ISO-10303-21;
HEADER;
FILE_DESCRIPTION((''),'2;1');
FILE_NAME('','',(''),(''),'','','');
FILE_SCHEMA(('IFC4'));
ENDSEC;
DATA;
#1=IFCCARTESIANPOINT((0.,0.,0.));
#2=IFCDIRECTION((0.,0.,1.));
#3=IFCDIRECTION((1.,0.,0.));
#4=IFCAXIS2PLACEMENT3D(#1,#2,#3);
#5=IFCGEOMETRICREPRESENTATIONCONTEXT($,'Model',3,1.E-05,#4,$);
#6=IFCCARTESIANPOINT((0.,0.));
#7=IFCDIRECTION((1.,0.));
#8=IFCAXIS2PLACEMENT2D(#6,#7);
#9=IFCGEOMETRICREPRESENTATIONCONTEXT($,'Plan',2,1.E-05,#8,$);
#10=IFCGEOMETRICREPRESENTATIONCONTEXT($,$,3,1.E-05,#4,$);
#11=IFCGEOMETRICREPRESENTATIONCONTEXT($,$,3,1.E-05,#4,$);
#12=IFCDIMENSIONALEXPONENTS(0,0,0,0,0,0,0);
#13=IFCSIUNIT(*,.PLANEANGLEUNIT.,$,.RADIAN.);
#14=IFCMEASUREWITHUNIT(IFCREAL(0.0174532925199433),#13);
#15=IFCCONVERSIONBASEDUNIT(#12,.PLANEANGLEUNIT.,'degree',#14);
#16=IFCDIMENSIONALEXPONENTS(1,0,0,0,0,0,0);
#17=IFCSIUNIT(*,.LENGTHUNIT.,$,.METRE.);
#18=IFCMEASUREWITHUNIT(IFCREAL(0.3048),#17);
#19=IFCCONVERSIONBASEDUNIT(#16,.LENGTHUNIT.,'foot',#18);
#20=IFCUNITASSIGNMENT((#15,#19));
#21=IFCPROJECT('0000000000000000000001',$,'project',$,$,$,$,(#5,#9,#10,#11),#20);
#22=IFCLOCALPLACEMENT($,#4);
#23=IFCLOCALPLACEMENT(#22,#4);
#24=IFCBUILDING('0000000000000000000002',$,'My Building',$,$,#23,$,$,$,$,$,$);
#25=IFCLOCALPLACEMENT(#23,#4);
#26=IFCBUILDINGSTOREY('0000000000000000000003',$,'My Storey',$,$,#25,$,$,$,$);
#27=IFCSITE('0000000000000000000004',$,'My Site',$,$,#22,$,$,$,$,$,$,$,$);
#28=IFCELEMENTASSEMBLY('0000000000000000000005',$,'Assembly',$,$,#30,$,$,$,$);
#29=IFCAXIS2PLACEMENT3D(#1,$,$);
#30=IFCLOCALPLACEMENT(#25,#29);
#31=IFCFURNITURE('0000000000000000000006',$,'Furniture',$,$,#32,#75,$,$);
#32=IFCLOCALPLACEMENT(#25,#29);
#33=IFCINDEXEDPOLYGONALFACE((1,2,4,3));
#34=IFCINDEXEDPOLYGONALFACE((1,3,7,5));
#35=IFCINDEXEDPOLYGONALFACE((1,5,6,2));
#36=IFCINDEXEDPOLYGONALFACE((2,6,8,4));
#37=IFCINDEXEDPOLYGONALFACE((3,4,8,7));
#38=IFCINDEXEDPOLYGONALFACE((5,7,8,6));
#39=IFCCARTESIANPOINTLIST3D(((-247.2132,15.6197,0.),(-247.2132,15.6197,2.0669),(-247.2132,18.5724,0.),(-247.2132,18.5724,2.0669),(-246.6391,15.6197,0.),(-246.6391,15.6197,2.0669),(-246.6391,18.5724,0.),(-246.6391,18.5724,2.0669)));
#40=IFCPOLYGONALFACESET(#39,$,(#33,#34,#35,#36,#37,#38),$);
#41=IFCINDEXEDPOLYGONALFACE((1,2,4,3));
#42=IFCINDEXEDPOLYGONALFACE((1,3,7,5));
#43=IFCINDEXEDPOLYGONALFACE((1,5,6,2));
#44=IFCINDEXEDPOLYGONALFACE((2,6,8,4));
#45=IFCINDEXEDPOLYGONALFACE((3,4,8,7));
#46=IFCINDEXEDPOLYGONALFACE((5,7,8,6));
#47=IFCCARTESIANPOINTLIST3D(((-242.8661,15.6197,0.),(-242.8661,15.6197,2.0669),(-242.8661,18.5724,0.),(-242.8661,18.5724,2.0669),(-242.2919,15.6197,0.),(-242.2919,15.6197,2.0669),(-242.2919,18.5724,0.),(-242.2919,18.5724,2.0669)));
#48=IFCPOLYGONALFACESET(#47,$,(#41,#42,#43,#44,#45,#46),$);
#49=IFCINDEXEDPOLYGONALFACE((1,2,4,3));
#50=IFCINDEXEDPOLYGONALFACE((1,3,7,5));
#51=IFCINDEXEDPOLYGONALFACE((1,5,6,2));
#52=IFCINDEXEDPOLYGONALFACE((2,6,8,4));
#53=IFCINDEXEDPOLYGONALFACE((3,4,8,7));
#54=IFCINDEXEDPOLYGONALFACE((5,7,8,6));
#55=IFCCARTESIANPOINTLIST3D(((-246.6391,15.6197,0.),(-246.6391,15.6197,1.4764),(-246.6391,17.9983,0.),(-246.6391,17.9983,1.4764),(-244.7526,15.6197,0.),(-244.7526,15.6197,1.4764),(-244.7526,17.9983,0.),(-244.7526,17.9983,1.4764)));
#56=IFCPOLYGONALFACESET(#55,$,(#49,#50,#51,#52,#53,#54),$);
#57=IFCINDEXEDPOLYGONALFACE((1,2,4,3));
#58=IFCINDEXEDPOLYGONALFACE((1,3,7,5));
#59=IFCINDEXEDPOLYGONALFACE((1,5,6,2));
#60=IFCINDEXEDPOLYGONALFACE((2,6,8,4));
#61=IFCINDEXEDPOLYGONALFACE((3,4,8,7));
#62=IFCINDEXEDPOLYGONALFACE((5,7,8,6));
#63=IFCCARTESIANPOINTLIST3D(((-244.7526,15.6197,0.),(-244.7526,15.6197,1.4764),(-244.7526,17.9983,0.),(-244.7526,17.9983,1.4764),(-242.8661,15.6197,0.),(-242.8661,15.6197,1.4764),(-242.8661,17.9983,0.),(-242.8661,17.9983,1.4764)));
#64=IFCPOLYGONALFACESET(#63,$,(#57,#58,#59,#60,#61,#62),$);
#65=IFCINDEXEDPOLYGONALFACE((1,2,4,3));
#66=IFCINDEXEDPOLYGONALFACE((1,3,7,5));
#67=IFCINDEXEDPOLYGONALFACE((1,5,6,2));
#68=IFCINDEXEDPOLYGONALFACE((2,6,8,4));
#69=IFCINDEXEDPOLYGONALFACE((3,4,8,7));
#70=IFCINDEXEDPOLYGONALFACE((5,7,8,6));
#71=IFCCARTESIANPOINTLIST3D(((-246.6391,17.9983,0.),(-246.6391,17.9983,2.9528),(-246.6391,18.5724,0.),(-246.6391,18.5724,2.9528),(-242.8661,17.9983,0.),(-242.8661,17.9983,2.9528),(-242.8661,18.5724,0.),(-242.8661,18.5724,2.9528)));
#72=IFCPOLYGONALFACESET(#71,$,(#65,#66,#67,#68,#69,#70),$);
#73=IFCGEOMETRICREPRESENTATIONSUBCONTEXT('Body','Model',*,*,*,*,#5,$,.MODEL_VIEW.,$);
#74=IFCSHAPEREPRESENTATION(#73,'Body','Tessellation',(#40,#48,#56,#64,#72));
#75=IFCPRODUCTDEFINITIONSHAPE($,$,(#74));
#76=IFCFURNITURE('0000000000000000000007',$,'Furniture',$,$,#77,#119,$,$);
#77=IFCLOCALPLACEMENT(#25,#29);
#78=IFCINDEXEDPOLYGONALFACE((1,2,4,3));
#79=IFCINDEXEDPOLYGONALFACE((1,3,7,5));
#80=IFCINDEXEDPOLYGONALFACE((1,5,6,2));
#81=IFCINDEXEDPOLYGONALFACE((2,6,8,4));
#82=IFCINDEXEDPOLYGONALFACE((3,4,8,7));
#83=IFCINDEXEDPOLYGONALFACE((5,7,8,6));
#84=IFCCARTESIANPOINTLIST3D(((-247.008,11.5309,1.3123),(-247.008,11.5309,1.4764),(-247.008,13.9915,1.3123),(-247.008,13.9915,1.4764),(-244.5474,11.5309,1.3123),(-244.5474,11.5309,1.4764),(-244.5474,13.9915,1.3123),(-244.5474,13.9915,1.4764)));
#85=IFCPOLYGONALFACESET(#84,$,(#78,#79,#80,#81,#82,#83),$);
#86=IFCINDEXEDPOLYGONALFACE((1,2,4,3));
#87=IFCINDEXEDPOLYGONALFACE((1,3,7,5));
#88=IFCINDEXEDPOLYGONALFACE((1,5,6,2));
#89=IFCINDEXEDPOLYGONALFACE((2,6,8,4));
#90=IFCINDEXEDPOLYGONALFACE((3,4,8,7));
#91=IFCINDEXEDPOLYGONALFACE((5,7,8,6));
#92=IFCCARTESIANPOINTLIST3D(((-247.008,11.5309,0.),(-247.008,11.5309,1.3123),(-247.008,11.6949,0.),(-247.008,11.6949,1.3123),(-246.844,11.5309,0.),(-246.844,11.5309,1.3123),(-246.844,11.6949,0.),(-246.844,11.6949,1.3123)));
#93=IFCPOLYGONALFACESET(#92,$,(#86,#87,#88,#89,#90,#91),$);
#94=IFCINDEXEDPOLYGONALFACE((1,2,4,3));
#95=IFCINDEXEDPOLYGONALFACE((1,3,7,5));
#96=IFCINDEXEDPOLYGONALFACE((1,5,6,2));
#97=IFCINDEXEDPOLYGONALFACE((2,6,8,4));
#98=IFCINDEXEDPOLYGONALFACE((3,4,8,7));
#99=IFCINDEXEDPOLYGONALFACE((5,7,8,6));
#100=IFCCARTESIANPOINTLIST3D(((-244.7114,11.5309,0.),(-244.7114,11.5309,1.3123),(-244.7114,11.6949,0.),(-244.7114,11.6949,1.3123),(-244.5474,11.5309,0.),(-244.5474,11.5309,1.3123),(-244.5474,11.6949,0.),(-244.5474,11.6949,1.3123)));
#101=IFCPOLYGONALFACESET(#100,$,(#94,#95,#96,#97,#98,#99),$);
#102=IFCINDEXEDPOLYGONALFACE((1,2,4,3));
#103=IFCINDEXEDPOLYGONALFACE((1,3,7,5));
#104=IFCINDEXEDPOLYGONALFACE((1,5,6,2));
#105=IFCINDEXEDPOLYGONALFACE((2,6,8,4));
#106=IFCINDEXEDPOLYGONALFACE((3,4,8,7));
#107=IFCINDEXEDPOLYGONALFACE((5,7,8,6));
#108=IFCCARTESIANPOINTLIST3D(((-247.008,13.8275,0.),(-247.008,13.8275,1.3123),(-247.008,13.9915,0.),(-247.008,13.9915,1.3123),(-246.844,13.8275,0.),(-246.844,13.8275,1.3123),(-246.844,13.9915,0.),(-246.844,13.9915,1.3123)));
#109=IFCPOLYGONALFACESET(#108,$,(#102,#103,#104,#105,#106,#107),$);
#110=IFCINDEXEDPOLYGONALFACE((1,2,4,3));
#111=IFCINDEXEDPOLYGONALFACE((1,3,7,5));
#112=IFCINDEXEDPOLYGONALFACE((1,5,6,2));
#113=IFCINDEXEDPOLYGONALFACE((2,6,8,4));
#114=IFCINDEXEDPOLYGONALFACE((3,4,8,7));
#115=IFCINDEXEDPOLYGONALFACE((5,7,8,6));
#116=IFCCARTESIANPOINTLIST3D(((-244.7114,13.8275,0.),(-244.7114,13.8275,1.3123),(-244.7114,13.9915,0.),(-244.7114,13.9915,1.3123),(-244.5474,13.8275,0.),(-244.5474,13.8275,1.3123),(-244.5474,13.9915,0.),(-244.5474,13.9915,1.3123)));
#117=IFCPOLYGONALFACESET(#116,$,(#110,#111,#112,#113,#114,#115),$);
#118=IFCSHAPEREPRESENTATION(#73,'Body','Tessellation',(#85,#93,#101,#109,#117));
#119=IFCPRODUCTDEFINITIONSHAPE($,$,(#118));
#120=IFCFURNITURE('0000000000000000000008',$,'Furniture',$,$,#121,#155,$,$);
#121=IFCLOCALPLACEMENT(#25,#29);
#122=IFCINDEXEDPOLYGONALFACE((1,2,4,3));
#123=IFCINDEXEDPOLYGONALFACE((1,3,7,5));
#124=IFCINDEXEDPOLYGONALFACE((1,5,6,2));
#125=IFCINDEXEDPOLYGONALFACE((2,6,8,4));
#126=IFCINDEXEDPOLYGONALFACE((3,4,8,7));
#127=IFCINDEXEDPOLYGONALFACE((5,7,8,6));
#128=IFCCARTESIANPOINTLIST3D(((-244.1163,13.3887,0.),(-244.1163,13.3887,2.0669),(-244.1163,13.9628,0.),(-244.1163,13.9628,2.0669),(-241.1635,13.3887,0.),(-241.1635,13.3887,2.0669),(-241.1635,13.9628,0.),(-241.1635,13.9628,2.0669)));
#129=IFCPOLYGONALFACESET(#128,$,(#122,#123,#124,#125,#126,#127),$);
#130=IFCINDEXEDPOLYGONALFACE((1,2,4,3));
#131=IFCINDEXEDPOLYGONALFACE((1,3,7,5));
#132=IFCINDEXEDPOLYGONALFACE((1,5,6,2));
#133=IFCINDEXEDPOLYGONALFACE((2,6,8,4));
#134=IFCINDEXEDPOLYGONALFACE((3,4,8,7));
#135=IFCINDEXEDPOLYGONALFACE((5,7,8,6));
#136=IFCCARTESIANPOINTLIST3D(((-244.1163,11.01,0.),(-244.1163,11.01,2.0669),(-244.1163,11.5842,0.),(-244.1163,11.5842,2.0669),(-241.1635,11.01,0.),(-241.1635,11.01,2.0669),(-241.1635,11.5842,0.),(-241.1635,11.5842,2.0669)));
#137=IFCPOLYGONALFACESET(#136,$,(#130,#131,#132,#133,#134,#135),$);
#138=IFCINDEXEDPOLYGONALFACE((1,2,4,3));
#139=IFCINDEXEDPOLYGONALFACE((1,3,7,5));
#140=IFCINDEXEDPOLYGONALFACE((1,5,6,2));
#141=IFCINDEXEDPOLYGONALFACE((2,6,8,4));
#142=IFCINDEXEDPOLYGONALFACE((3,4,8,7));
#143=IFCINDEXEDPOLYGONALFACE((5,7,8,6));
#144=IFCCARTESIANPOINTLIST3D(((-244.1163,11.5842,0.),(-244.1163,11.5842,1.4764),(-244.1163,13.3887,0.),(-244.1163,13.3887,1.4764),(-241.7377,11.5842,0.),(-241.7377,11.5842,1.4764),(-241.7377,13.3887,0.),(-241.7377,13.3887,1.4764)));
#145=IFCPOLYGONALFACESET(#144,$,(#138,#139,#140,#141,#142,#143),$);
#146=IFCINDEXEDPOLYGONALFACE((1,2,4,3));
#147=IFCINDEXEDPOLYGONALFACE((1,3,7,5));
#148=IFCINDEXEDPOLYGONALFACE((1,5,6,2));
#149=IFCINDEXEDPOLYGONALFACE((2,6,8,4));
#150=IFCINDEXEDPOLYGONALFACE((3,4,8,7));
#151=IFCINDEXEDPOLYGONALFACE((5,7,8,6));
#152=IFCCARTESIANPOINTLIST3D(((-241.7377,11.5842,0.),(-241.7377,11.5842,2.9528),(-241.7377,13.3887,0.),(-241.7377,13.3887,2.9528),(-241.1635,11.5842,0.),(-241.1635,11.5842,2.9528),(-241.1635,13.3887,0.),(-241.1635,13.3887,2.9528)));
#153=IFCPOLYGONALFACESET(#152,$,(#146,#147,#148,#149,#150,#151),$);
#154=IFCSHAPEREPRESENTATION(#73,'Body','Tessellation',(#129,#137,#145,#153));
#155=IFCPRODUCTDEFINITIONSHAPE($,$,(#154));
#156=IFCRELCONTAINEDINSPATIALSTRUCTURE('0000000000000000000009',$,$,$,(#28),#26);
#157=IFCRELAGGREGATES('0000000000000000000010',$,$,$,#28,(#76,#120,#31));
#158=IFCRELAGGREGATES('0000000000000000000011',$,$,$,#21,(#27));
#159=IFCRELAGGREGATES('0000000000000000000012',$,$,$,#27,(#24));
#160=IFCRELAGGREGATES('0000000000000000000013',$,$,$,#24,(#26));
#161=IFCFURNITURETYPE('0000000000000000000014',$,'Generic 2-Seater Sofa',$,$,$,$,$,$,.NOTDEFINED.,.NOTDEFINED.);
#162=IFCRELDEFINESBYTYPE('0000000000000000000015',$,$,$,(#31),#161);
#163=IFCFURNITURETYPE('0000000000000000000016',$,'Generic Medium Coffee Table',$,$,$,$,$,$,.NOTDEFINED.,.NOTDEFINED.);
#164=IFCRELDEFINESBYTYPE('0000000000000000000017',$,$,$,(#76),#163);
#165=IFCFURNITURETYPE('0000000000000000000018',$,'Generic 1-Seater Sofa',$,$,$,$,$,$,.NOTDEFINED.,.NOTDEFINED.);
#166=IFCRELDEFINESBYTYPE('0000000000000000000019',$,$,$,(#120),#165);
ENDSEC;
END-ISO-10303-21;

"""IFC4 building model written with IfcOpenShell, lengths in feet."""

from ifc_helpers import new_model, entity, si_unit, converted_unit, frame, origin_with_axes, origin_2d_with_axis, place, context, subcontext, project, spatial, line, indexed_curve, outline, extrude, shape, source, transform, mapped, type_object, type_shapes, element, aggregate, save


model = new_model("IFC4")

# Units and contexts
model_context = context("Model", 3, precision=1e-05, world=origin_with_axes())
plan_context = context("Plan", 2, precision=1e-05, world=origin_2d_with_axis())
context_of_model_1 = context(None, 3, precision=1e-05, world=origin_with_axes())
context_of_model_2 = context(None, 3, precision=1e-05, world=origin_with_axes())
body_context_1 = subcontext(model_context, "Body", "Model", "MODEL_VIEW")
body_context_2 = subcontext(plan_context, "Body", "Plan", "PLAN_VIEW")
ifc_project = project(units=[converted_unit("PLANEANGLEUNIT", "degree", entity("IfcReal", 0.0174532925199433), si_unit("PLANEANGLEUNIT", "RADIAN"), dimensions=[0, 0, 0, 0, 0, 0, 0]), converted_unit("LENGTHUNIT", "foot", entity("IfcReal", 0.3048), si_unit("LENGTHUNIT", "METRE"), dimensions=[1, 0, 0, 0, 0, 0, 0])], contexts=[model_context, plan_context, context_of_model_1, context_of_model_2])

# Site, building, storey
site_placement = place(None, origin_with_axes())
site = spatial("IfcSite", under=ifc_project, at=site_placement, Name="My Site")
building_placement = place(site_placement, origin_with_axes())
building = spatial("IfcBuilding", under=site, at=building_placement, Name="My Building")
storey_placement = place(building_placement, origin_with_axes())
storey = spatial("IfcBuildingStorey", under=building, at=storey_placement, Name="My Storey")

# Element assembly
assembly_1_placement = place(storey_placement, origin_with_axes())
assembly_1 = element("IfcElementAssembly", 1, at=assembly_1_placement, inside=storey, Name="Assembly")

# Furniture
furniture_type_1 = type_object("IfcFurnitureType", Name="Generic 2-Seater Sofa", AssemblyPlace="NOTDEFINED", PredefinedType="NOTDEFINED")
shared_shape_1 = source(origin_with_axes(), body_context_1, "Body", "SweptSolid", [
    extrude(outline(indexed_curve([(0.0, 0.0), (0.5741, 0.0), (0.5741, 2.9528), (0.0, 2.9528)], segments=[line(1, 2), line(2, 3), line(3, 4), line(4, 1)])), frame((-2.4606, -2.9528, 0.0), z_axis=(0.0, 0.0, 1.0), x_axis=(1.0, 0.0, 0.0)), (0.0, 0.0, 1.0), 2.0669),
    extrude(outline(indexed_curve([(0.0, 0.0), (0.5741, 0.0), (0.5741, 2.9528), (0.0, 2.9528)], segments=[line(1, 2), line(2, 3), line(3, 4), line(4, 1)])), frame((1.8865, -2.9528, 0.0), z_axis=(0.0, 0.0, 1.0), x_axis=(1.0, 0.0, 0.0)), (0.0, 0.0, 1.0), 2.0669),
    extrude(outline(indexed_curve([(0.5741, 0.0), (2.4606, 0.0), (2.4606, 2.3786), (0.5741, 2.3786)], segments=[line(1, 2), line(2, 3), line(3, 4), line(4, 1)])), frame((-2.4606, -2.9528, 0.0), z_axis=(0.0, 0.0, 1.0), x_axis=(1.0, 0.0, 0.0)), (0.0, 0.0, 1.0), 1.4764),
    extrude(outline(indexed_curve([(2.4606, 0.0), (4.3471, 0.0), (4.3471, 2.3786), (2.4606, 2.3786)], segments=[line(1, 2), line(2, 3), line(3, 4), line(4, 1)])), frame((-2.4606, -2.9528, 0.0), z_axis=(0.0, 0.0, 1.0), x_axis=(1.0, 0.0, 0.0)), (0.0, 0.0, 1.0), 1.4764),
    extrude(outline(indexed_curve([(0.5741, 2.3786), (4.3471, 2.3786), (4.3471, 2.9528), (0.5741, 2.9528)], segments=[line(1, 2), line(2, 3), line(3, 4), line(4, 1)])), frame((-2.4606, -2.9528, 0.0), z_axis=(0.0, 0.0, 1.0), x_axis=(1.0, 0.0, 0.0)), (0.0, 0.0, 1.0), 2.9528),
])
shared_shape_2 = source(origin_with_axes(), body_context_2, "Body", "Curve2D", [
    entity("IfcIndexedPolyCurve", entity("IfcCartesianPointList2D", [[-2.4606, -2.9528], [-1.8865, -2.9528], [-1.8865, 0.0], [-2.4606, 0.0]]), [entity("IfcLineIndex", [1, 2]), entity("IfcLineIndex", [2, 3]), entity("IfcLineIndex", [3, 4]), entity("IfcLineIndex", [4, 1])]),
    entity("IfcIndexedPolyCurve", entity("IfcCartesianPointList2D", [[1.8865, -2.9528], [2.4606, -2.9528], [2.4606, 0.0], [1.8865, 0.0]]), [entity("IfcLineIndex", [1, 2]), entity("IfcLineIndex", [2, 3]), entity("IfcLineIndex", [3, 4]), entity("IfcLineIndex", [4, 1])]),
    entity("IfcIndexedPolyCurve", entity("IfcCartesianPointList2D", [[-1.8865, -2.9528], [0.0, -2.9528], [0.0, -0.5741], [-1.8865, -0.5741]]), [entity("IfcLineIndex", [1, 2]), entity("IfcLineIndex", [2, 3]), entity("IfcLineIndex", [3, 4]), entity("IfcLineIndex", [4, 1])]),
    entity("IfcIndexedPolyCurve", entity("IfcCartesianPointList2D", [[0.0, -2.9528], [1.8865, -2.9528], [1.8865, -0.5741], [0.0, -0.5741]]), [entity("IfcLineIndex", [1, 2]), entity("IfcLineIndex", [2, 3]), entity("IfcLineIndex", [3, 4]), entity("IfcLineIndex", [4, 1])]),
    entity("IfcIndexedPolyCurve", entity("IfcCartesianPointList2D", [[-1.8865, -0.5741], [1.8865, -0.5741], [1.8865, 0.0], [-1.8865, 0.0]]), [entity("IfcLineIndex", [1, 2]), entity("IfcLineIndex", [2, 3]), entity("IfcLineIndex", [3, 4]), entity("IfcLineIndex", [4, 1])]),
])
type_shapes(furniture_type_1, [shared_shape_1, shared_shape_2])
furniture_1_placement = place(assembly_1_placement, frame((-244.7526, 18.5724, 0.0), z_axis=(0.0, 0.0, 1.0), x_axis=(1.0, 0.0, 0.0)))
furniture_1 = element("IfcFurniture", 2, at=furniture_1_placement, type_object=furniture_type_1, Name="Furniture", shapes=[
    shape(body_context_1, "Body", "MappedRepresentation", [mapped(shared_shape_1, transform((0.0, 0.0, 0.0), x_axis=(1.0, 0.0, 0.0), y_axis=(0.0, 1.0, 0.0), z_axis=(0.0, 0.0, 1.0), scale=1.0))]),
    shape(body_context_2, "Body", "MappedRepresentation", [mapped(shared_shape_2, transform((0.0, 0.0, 0.0), x_axis=(1.0, 0.0, 0.0), y_axis=(0.0, 1.0, 0.0), z_axis=(0.0, 0.0, 1.0), scale=1.0))]),
])
furniture_type_2 = type_object("IfcFurnitureType", Name="Generic Medium Coffee Table", AssemblyPlace="NOTDEFINED", PredefinedType="NOTDEFINED")
shared_shape_3 = source(origin_with_axes(), body_context_1, "Body", "SweptSolid", [
    extrude(outline(indexed_curve([(0.0, 0.0), (2.4606, 0.0), (2.4606, 2.4606), (0.0, 2.4606)], segments=[line(1, 2), line(2, 3), line(3, 4), line(4, 1)])), frame((-1.2303, -1.2303, 1.3123), z_axis=(0.0, 0.0, 1.0), x_axis=(1.0, 0.0, 0.0)), (0.0, 0.0, 1.0), 0.164),
    extrude(outline(indexed_curve([(0.0, 0.0), (0.164, 0.0), (0.164, 0.164), (0.0, 0.164)], segments=[line(1, 2), line(2, 3), line(3, 4), line(4, 1)])), frame((-1.2303, -1.2303, 0.0), z_axis=(0.0, 0.0, 1.0), x_axis=(1.0, 0.0, 0.0)), (0.0, 0.0, 1.0), 1.3123),
    extrude(outline(indexed_curve([(2.4606, 0.0), (2.2966, 0.0), (2.2966, 0.164), (2.4606, 0.164)], segments=[line(1, 2), line(2, 3), line(3, 4), line(4, 1)])), frame((-1.2303, -1.2303, 0.0), z_axis=(0.0, 0.0, 1.0), x_axis=(1.0, 0.0, 0.0)), (0.0, 0.0, 1.0), 1.3123),
    extrude(outline(indexed_curve([(0.0, 2.4606), (0.164, 2.4606), (0.164, 2.2966), (0.0, 2.2966)], segments=[line(1, 2), line(2, 3), line(3, 4), line(4, 1)])), frame((-1.2303, -1.2303, 0.0), z_axis=(0.0, 0.0, 1.0), x_axis=(1.0, 0.0, 0.0)), (0.0, 0.0, 1.0), 1.3123),
    extrude(outline(indexed_curve([(2.4606, 2.4606), (2.2966, 2.4606), (2.2966, 2.2966), (2.4606, 2.2966)], segments=[line(1, 2), line(2, 3), line(3, 4), line(4, 1)])), frame((-1.2303, -1.2303, 0.0), z_axis=(0.0, 0.0, 1.0), x_axis=(1.0, 0.0, 0.0)), (0.0, 0.0, 1.0), 1.3123),
])
shared_shape_4 = source(origin_with_axes(), body_context_2, "Body", "Annotation2D", [
    entity("IfcAnnotationFillArea", entity("IfcIndexedPolyCurve", entity("IfcCartesianPointList2D", [[-1.2303, -1.2303], [1.2303, -1.2303], [1.2303, 1.2303], [-1.2303, 1.2303]]), [entity("IfcLineIndex", [1, 4]), entity("IfcLineIndex", [4, 3]), entity("IfcLineIndex", [3, 2]), entity("IfcLineIndex", [2, 1])])),
])
type_shapes(furniture_type_2, [shared_shape_3, shared_shape_4])
furniture_2_placement = place(assembly_1_placement, frame((-245.7777, 12.7612, 0.0), z_axis=(0.0, 0.0, 1.0), x_axis=(1.0, 0.0, 0.0)))
furniture_2 = element("IfcFurniture", 3, at=furniture_2_placement, type_object=furniture_type_2, Name="Furniture", shapes=[
    shape(body_context_1, "Body", "MappedRepresentation", [mapped(shared_shape_3, transform((0.0, 0.0, 0.0), x_axis=(1.0, 0.0, 0.0), y_axis=(0.0, 1.0, 0.0), z_axis=(0.0, 0.0, 1.0), scale=1.0))]),
    shape(body_context_2, "Body", "MappedRepresentation", [mapped(shared_shape_4, transform((0.0, 0.0, 0.0), x_axis=(1.0, 0.0, 0.0), y_axis=(0.0, 1.0, 0.0), z_axis=(0.0, 0.0, 1.0), scale=1.0))]),
])
furniture_type_3 = type_object("IfcFurnitureType", Name="Generic 1-Seater Sofa", AssemblyPlace="NOTDEFINED", PredefinedType="NOTDEFINED")
shared_shape_5 = source(origin_with_axes(), body_context_1, "Body", "SweptSolid", [
    extrude(outline(indexed_curve([(0.0, 0.0), (0.5741, 0.0), (0.5741, 2.9528), (0.0, 2.9528)], segments=[line(1, 2, 3, 4, 1)])), frame((-1.4764, -2.9528, 0.0), z_axis=(0.0, 0.0, 1.0), x_axis=(1.0, 0.0, 0.0)), (0.0, 0.0, 1.0), 2.0669),
    extrude(outline(indexed_curve([(0.0, 0.0), (0.5741, 0.0), (0.5741, 2.9528), (0.0, 2.9528)], segments=[line(1, 2, 3, 4, 1)])), frame((0.9022, -2.9528, 0.0), z_axis=(0.0, 0.0, 1.0), x_axis=(1.0, 0.0, 0.0)), (0.0, 0.0, 1.0), 2.0669),
    extrude(outline(indexed_curve([(0.5741, 0.0), (2.3786, 0.0), (2.3786, 2.3786), (0.5741, 2.3786)], segments=[line(1, 2, 3, 4, 1)])), frame((-1.4764, -2.9528, 0.0), z_axis=(0.0, 0.0, 1.0), x_axis=(1.0, 0.0, 0.0)), (0.0, 0.0, 1.0), 1.4764),
    extrude(outline(indexed_curve([(0.5741, 2.3786), (2.3786, 2.3786), (2.3786, 2.9528), (0.5741, 2.9528)], segments=[line(1, 2, 3, 4, 1)])), frame((-1.4764, -2.9528, 0.0), z_axis=(0.0, 0.0, 1.0), x_axis=(1.0, 0.0, 0.0)), (0.0, 0.0, 1.0), 2.9528),
])
shared_shape_6 = source(origin_with_axes(), body_context_2, "Body", "Curve2D", [
    entity("IfcIndexedPolyCurve", entity("IfcCartesianPointList2D", [[-1.4764, -2.9528], [-0.9022, -2.9528], [-0.9022, 0.0], [-1.4764, 0.0]]), [entity("IfcLineIndex", [1, 2, 3, 4, 1])]),
    entity("IfcIndexedPolyCurve", entity("IfcCartesianPointList2D", [[0.9022, -2.9528], [1.4764, -2.9528], [1.4764, 0.0], [0.9022, 0.0]]), [entity("IfcLineIndex", [1, 2, 3, 4, 1])]),
    entity("IfcIndexedPolyCurve", entity("IfcCartesianPointList2D", [[-0.9022, -2.9528], [0.9022, -2.9528], [0.9022, -0.5741], [-0.9022, -0.5741]]), [entity("IfcLineIndex", [1, 2, 3, 4, 1])]),
    entity("IfcIndexedPolyCurve", entity("IfcCartesianPointList2D", [[-0.9022, -0.5741], [0.9022, -0.5741], [0.9022, 0.0], [-0.9022, 0.0]]), [entity("IfcLineIndex", [1, 2, 3, 4, 1])]),
])
type_shapes(furniture_type_3, [shared_shape_5, shared_shape_6])
furniture_3_placement = place(assembly_1_placement, frame((-241.1635, 12.4864, 0.0), z_axis=(0.0, 0.0, 1.0), x_axis=(0.000001, -1.0, 0.0)))
furniture_3 = element("IfcFurniture", 4, at=furniture_3_placement, type_object=furniture_type_3, Name="Furniture", shapes=[
    shape(body_context_1, "Body", "MappedRepresentation", [mapped(shared_shape_5, transform((0.0, 0.0, 0.0), x_axis=(1.0, 0.0, 0.0), y_axis=(0.0, 1.0, 0.0), z_axis=(0.0, 0.0, 1.0), scale=1.0))]),
    shape(body_context_2, "Body", "MappedRepresentation", [mapped(shared_shape_6, transform((0.0, 0.0, 0.0), x_axis=(1.0, 0.0, 0.0), y_axis=(0.0, 1.0, 0.0), z_axis=(0.0, 0.0, 1.0), scale=1.0))]),
])
aggregate(assembly_1, [furniture_2, furniture_3, furniture_1])

save(model, "model.ifc")
